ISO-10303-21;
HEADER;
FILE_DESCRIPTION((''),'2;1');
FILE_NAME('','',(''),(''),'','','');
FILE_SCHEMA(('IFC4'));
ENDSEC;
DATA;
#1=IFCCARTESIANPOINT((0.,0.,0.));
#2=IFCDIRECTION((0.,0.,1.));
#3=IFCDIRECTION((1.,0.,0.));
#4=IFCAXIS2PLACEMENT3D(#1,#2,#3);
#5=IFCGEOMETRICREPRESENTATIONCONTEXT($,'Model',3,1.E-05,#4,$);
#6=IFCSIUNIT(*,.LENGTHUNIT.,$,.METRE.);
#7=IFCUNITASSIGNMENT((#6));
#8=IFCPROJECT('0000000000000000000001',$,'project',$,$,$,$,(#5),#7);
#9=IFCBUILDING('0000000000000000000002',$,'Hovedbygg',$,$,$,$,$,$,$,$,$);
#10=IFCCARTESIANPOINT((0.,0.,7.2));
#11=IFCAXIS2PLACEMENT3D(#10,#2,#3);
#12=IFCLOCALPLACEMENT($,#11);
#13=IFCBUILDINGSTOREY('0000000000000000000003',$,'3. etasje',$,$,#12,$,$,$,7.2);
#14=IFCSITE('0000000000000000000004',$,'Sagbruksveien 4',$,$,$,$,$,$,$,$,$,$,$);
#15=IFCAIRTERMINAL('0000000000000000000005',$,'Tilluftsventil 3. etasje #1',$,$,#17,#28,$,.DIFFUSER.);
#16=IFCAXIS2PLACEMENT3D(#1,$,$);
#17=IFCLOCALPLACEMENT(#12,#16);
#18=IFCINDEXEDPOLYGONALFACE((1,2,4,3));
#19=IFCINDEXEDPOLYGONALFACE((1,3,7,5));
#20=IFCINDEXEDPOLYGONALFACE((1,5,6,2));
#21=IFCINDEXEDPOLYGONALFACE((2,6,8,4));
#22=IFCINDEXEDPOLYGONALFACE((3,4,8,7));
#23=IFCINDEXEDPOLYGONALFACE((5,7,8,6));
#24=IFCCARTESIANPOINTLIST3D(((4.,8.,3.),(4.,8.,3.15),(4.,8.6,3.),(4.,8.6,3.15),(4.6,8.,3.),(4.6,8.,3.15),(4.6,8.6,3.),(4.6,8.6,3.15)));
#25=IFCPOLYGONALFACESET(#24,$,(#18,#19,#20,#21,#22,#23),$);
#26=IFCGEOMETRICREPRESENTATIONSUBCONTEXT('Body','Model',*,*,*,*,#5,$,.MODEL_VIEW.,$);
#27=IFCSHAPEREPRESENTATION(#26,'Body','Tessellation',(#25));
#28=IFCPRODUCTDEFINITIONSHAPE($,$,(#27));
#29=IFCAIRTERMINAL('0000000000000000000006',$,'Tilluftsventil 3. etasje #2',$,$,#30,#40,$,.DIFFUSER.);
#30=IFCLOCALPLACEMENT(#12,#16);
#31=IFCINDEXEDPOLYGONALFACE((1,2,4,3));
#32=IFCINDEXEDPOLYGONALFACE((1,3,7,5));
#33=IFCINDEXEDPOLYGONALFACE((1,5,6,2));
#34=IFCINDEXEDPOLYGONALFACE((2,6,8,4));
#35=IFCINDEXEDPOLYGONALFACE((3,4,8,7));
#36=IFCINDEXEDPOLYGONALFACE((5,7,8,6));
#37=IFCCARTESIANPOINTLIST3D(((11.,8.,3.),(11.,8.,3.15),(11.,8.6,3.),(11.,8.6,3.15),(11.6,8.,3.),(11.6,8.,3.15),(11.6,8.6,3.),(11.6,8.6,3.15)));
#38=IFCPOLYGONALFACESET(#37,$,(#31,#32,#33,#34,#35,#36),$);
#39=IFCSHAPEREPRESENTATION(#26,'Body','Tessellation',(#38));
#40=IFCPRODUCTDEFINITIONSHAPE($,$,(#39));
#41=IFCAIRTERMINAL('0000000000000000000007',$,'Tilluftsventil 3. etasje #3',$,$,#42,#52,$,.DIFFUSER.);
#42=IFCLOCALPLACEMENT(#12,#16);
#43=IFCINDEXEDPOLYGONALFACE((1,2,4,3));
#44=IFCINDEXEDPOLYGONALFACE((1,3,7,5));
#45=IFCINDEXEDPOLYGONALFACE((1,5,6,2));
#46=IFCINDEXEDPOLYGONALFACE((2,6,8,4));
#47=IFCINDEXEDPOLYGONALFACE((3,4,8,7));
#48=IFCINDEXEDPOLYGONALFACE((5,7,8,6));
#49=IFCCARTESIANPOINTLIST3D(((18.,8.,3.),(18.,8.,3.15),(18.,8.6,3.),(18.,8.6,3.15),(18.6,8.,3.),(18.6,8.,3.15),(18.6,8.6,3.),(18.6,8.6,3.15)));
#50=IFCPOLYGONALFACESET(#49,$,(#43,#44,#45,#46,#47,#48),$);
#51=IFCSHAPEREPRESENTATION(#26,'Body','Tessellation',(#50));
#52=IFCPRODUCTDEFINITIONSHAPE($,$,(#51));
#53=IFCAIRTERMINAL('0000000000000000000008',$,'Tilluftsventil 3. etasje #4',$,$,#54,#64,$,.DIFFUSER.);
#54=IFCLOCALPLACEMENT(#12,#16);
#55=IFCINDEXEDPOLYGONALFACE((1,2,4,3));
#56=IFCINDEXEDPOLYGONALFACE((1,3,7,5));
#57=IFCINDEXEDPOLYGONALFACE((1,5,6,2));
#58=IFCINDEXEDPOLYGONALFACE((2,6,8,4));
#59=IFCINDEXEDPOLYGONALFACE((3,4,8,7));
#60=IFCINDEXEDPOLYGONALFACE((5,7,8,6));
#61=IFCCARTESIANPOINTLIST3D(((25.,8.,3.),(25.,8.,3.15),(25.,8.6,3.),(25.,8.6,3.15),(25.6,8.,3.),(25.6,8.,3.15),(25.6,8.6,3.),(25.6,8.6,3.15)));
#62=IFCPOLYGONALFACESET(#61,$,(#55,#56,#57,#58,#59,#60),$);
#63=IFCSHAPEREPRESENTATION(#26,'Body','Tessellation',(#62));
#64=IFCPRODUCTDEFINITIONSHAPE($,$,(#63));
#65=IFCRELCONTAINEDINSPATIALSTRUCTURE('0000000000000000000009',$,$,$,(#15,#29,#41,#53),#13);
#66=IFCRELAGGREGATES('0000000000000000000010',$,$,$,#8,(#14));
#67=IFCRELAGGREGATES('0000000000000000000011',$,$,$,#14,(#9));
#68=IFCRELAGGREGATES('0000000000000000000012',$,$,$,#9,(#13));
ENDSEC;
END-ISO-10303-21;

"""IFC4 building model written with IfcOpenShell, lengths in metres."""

from ifc_helpers import new_model, si_unit, frame, origin_with_axes, place, context, subcontext, project, spatial, line, indexed_curve, outline, extrude, element, save


model = new_model("IFC4")

# Units and contexts
model_context = context("Model", 3, precision=1e-05, world=origin_with_axes())
body_context = subcontext(model_context, "Body", "Model", "MODEL_VIEW")
ifc_project = project(units=[si_unit("LENGTHUNIT", "METRE")], contexts=[model_context])

# Site, building, storey
site = spatial("IfcSite", under=ifc_project, Name="Sagbruksveien 4")
building = spatial("IfcBuilding", under=site, Name="Hovedbygg")
storey_placement = place(None, frame((0.0, 0.0, 7.2), z_axis=(0.0, 0.0, 1.0), x_axis=(1.0, 0.0, 0.0)))
storey = spatial("IfcBuildingStorey", under=building, at=storey_placement, Name="3. etasje", Elevation=7.2)

# Air terminals
for number, where, z_axis, x_axis, name in (
    (1, (4.0, 8.0, 3.0), (0.0, 0.0, 1.0), (1.0, 0.0, 0.0), "Tilluftsventil 3. etasje #1"),
    (2, (11.0, 8.0, 3.0), (0.0, 0.0, 1.0), (1.0, 0.0, 0.0), "Tilluftsventil 3. etasje #2"),
    (3, (18.0, 8.0, 3.0), (0.0, 0.0, 1.0), (1.0, 0.0, 0.0), "Tilluftsventil 3. etasje #3"),
    (4, (25.0, 8.0, 3.0), (0.0, 0.0, 1.0), (1.0, 0.0, 0.0), "Tilluftsventil 3. etasje #4"),
):
    element("IfcAirTerminal", number, at=place(storey_placement, frame(where, z_axis=z_axis, x_axis=x_axis)), inside=storey, Name=name, PredefinedType="DIFFUSER", context=body_context, shape_type="SweptSolid", body=[
        extrude(outline(indexed_curve([(0.0, 0.0), (0.6, 0.0), (0.6, 0.6), (0.0, 0.6)], segments=[line(1, 2, 3, 4, 1)])), origin_with_axes(), (0.0, 0.0, 1.0), 0.15),
    ])

save(model, "model.ifc")
